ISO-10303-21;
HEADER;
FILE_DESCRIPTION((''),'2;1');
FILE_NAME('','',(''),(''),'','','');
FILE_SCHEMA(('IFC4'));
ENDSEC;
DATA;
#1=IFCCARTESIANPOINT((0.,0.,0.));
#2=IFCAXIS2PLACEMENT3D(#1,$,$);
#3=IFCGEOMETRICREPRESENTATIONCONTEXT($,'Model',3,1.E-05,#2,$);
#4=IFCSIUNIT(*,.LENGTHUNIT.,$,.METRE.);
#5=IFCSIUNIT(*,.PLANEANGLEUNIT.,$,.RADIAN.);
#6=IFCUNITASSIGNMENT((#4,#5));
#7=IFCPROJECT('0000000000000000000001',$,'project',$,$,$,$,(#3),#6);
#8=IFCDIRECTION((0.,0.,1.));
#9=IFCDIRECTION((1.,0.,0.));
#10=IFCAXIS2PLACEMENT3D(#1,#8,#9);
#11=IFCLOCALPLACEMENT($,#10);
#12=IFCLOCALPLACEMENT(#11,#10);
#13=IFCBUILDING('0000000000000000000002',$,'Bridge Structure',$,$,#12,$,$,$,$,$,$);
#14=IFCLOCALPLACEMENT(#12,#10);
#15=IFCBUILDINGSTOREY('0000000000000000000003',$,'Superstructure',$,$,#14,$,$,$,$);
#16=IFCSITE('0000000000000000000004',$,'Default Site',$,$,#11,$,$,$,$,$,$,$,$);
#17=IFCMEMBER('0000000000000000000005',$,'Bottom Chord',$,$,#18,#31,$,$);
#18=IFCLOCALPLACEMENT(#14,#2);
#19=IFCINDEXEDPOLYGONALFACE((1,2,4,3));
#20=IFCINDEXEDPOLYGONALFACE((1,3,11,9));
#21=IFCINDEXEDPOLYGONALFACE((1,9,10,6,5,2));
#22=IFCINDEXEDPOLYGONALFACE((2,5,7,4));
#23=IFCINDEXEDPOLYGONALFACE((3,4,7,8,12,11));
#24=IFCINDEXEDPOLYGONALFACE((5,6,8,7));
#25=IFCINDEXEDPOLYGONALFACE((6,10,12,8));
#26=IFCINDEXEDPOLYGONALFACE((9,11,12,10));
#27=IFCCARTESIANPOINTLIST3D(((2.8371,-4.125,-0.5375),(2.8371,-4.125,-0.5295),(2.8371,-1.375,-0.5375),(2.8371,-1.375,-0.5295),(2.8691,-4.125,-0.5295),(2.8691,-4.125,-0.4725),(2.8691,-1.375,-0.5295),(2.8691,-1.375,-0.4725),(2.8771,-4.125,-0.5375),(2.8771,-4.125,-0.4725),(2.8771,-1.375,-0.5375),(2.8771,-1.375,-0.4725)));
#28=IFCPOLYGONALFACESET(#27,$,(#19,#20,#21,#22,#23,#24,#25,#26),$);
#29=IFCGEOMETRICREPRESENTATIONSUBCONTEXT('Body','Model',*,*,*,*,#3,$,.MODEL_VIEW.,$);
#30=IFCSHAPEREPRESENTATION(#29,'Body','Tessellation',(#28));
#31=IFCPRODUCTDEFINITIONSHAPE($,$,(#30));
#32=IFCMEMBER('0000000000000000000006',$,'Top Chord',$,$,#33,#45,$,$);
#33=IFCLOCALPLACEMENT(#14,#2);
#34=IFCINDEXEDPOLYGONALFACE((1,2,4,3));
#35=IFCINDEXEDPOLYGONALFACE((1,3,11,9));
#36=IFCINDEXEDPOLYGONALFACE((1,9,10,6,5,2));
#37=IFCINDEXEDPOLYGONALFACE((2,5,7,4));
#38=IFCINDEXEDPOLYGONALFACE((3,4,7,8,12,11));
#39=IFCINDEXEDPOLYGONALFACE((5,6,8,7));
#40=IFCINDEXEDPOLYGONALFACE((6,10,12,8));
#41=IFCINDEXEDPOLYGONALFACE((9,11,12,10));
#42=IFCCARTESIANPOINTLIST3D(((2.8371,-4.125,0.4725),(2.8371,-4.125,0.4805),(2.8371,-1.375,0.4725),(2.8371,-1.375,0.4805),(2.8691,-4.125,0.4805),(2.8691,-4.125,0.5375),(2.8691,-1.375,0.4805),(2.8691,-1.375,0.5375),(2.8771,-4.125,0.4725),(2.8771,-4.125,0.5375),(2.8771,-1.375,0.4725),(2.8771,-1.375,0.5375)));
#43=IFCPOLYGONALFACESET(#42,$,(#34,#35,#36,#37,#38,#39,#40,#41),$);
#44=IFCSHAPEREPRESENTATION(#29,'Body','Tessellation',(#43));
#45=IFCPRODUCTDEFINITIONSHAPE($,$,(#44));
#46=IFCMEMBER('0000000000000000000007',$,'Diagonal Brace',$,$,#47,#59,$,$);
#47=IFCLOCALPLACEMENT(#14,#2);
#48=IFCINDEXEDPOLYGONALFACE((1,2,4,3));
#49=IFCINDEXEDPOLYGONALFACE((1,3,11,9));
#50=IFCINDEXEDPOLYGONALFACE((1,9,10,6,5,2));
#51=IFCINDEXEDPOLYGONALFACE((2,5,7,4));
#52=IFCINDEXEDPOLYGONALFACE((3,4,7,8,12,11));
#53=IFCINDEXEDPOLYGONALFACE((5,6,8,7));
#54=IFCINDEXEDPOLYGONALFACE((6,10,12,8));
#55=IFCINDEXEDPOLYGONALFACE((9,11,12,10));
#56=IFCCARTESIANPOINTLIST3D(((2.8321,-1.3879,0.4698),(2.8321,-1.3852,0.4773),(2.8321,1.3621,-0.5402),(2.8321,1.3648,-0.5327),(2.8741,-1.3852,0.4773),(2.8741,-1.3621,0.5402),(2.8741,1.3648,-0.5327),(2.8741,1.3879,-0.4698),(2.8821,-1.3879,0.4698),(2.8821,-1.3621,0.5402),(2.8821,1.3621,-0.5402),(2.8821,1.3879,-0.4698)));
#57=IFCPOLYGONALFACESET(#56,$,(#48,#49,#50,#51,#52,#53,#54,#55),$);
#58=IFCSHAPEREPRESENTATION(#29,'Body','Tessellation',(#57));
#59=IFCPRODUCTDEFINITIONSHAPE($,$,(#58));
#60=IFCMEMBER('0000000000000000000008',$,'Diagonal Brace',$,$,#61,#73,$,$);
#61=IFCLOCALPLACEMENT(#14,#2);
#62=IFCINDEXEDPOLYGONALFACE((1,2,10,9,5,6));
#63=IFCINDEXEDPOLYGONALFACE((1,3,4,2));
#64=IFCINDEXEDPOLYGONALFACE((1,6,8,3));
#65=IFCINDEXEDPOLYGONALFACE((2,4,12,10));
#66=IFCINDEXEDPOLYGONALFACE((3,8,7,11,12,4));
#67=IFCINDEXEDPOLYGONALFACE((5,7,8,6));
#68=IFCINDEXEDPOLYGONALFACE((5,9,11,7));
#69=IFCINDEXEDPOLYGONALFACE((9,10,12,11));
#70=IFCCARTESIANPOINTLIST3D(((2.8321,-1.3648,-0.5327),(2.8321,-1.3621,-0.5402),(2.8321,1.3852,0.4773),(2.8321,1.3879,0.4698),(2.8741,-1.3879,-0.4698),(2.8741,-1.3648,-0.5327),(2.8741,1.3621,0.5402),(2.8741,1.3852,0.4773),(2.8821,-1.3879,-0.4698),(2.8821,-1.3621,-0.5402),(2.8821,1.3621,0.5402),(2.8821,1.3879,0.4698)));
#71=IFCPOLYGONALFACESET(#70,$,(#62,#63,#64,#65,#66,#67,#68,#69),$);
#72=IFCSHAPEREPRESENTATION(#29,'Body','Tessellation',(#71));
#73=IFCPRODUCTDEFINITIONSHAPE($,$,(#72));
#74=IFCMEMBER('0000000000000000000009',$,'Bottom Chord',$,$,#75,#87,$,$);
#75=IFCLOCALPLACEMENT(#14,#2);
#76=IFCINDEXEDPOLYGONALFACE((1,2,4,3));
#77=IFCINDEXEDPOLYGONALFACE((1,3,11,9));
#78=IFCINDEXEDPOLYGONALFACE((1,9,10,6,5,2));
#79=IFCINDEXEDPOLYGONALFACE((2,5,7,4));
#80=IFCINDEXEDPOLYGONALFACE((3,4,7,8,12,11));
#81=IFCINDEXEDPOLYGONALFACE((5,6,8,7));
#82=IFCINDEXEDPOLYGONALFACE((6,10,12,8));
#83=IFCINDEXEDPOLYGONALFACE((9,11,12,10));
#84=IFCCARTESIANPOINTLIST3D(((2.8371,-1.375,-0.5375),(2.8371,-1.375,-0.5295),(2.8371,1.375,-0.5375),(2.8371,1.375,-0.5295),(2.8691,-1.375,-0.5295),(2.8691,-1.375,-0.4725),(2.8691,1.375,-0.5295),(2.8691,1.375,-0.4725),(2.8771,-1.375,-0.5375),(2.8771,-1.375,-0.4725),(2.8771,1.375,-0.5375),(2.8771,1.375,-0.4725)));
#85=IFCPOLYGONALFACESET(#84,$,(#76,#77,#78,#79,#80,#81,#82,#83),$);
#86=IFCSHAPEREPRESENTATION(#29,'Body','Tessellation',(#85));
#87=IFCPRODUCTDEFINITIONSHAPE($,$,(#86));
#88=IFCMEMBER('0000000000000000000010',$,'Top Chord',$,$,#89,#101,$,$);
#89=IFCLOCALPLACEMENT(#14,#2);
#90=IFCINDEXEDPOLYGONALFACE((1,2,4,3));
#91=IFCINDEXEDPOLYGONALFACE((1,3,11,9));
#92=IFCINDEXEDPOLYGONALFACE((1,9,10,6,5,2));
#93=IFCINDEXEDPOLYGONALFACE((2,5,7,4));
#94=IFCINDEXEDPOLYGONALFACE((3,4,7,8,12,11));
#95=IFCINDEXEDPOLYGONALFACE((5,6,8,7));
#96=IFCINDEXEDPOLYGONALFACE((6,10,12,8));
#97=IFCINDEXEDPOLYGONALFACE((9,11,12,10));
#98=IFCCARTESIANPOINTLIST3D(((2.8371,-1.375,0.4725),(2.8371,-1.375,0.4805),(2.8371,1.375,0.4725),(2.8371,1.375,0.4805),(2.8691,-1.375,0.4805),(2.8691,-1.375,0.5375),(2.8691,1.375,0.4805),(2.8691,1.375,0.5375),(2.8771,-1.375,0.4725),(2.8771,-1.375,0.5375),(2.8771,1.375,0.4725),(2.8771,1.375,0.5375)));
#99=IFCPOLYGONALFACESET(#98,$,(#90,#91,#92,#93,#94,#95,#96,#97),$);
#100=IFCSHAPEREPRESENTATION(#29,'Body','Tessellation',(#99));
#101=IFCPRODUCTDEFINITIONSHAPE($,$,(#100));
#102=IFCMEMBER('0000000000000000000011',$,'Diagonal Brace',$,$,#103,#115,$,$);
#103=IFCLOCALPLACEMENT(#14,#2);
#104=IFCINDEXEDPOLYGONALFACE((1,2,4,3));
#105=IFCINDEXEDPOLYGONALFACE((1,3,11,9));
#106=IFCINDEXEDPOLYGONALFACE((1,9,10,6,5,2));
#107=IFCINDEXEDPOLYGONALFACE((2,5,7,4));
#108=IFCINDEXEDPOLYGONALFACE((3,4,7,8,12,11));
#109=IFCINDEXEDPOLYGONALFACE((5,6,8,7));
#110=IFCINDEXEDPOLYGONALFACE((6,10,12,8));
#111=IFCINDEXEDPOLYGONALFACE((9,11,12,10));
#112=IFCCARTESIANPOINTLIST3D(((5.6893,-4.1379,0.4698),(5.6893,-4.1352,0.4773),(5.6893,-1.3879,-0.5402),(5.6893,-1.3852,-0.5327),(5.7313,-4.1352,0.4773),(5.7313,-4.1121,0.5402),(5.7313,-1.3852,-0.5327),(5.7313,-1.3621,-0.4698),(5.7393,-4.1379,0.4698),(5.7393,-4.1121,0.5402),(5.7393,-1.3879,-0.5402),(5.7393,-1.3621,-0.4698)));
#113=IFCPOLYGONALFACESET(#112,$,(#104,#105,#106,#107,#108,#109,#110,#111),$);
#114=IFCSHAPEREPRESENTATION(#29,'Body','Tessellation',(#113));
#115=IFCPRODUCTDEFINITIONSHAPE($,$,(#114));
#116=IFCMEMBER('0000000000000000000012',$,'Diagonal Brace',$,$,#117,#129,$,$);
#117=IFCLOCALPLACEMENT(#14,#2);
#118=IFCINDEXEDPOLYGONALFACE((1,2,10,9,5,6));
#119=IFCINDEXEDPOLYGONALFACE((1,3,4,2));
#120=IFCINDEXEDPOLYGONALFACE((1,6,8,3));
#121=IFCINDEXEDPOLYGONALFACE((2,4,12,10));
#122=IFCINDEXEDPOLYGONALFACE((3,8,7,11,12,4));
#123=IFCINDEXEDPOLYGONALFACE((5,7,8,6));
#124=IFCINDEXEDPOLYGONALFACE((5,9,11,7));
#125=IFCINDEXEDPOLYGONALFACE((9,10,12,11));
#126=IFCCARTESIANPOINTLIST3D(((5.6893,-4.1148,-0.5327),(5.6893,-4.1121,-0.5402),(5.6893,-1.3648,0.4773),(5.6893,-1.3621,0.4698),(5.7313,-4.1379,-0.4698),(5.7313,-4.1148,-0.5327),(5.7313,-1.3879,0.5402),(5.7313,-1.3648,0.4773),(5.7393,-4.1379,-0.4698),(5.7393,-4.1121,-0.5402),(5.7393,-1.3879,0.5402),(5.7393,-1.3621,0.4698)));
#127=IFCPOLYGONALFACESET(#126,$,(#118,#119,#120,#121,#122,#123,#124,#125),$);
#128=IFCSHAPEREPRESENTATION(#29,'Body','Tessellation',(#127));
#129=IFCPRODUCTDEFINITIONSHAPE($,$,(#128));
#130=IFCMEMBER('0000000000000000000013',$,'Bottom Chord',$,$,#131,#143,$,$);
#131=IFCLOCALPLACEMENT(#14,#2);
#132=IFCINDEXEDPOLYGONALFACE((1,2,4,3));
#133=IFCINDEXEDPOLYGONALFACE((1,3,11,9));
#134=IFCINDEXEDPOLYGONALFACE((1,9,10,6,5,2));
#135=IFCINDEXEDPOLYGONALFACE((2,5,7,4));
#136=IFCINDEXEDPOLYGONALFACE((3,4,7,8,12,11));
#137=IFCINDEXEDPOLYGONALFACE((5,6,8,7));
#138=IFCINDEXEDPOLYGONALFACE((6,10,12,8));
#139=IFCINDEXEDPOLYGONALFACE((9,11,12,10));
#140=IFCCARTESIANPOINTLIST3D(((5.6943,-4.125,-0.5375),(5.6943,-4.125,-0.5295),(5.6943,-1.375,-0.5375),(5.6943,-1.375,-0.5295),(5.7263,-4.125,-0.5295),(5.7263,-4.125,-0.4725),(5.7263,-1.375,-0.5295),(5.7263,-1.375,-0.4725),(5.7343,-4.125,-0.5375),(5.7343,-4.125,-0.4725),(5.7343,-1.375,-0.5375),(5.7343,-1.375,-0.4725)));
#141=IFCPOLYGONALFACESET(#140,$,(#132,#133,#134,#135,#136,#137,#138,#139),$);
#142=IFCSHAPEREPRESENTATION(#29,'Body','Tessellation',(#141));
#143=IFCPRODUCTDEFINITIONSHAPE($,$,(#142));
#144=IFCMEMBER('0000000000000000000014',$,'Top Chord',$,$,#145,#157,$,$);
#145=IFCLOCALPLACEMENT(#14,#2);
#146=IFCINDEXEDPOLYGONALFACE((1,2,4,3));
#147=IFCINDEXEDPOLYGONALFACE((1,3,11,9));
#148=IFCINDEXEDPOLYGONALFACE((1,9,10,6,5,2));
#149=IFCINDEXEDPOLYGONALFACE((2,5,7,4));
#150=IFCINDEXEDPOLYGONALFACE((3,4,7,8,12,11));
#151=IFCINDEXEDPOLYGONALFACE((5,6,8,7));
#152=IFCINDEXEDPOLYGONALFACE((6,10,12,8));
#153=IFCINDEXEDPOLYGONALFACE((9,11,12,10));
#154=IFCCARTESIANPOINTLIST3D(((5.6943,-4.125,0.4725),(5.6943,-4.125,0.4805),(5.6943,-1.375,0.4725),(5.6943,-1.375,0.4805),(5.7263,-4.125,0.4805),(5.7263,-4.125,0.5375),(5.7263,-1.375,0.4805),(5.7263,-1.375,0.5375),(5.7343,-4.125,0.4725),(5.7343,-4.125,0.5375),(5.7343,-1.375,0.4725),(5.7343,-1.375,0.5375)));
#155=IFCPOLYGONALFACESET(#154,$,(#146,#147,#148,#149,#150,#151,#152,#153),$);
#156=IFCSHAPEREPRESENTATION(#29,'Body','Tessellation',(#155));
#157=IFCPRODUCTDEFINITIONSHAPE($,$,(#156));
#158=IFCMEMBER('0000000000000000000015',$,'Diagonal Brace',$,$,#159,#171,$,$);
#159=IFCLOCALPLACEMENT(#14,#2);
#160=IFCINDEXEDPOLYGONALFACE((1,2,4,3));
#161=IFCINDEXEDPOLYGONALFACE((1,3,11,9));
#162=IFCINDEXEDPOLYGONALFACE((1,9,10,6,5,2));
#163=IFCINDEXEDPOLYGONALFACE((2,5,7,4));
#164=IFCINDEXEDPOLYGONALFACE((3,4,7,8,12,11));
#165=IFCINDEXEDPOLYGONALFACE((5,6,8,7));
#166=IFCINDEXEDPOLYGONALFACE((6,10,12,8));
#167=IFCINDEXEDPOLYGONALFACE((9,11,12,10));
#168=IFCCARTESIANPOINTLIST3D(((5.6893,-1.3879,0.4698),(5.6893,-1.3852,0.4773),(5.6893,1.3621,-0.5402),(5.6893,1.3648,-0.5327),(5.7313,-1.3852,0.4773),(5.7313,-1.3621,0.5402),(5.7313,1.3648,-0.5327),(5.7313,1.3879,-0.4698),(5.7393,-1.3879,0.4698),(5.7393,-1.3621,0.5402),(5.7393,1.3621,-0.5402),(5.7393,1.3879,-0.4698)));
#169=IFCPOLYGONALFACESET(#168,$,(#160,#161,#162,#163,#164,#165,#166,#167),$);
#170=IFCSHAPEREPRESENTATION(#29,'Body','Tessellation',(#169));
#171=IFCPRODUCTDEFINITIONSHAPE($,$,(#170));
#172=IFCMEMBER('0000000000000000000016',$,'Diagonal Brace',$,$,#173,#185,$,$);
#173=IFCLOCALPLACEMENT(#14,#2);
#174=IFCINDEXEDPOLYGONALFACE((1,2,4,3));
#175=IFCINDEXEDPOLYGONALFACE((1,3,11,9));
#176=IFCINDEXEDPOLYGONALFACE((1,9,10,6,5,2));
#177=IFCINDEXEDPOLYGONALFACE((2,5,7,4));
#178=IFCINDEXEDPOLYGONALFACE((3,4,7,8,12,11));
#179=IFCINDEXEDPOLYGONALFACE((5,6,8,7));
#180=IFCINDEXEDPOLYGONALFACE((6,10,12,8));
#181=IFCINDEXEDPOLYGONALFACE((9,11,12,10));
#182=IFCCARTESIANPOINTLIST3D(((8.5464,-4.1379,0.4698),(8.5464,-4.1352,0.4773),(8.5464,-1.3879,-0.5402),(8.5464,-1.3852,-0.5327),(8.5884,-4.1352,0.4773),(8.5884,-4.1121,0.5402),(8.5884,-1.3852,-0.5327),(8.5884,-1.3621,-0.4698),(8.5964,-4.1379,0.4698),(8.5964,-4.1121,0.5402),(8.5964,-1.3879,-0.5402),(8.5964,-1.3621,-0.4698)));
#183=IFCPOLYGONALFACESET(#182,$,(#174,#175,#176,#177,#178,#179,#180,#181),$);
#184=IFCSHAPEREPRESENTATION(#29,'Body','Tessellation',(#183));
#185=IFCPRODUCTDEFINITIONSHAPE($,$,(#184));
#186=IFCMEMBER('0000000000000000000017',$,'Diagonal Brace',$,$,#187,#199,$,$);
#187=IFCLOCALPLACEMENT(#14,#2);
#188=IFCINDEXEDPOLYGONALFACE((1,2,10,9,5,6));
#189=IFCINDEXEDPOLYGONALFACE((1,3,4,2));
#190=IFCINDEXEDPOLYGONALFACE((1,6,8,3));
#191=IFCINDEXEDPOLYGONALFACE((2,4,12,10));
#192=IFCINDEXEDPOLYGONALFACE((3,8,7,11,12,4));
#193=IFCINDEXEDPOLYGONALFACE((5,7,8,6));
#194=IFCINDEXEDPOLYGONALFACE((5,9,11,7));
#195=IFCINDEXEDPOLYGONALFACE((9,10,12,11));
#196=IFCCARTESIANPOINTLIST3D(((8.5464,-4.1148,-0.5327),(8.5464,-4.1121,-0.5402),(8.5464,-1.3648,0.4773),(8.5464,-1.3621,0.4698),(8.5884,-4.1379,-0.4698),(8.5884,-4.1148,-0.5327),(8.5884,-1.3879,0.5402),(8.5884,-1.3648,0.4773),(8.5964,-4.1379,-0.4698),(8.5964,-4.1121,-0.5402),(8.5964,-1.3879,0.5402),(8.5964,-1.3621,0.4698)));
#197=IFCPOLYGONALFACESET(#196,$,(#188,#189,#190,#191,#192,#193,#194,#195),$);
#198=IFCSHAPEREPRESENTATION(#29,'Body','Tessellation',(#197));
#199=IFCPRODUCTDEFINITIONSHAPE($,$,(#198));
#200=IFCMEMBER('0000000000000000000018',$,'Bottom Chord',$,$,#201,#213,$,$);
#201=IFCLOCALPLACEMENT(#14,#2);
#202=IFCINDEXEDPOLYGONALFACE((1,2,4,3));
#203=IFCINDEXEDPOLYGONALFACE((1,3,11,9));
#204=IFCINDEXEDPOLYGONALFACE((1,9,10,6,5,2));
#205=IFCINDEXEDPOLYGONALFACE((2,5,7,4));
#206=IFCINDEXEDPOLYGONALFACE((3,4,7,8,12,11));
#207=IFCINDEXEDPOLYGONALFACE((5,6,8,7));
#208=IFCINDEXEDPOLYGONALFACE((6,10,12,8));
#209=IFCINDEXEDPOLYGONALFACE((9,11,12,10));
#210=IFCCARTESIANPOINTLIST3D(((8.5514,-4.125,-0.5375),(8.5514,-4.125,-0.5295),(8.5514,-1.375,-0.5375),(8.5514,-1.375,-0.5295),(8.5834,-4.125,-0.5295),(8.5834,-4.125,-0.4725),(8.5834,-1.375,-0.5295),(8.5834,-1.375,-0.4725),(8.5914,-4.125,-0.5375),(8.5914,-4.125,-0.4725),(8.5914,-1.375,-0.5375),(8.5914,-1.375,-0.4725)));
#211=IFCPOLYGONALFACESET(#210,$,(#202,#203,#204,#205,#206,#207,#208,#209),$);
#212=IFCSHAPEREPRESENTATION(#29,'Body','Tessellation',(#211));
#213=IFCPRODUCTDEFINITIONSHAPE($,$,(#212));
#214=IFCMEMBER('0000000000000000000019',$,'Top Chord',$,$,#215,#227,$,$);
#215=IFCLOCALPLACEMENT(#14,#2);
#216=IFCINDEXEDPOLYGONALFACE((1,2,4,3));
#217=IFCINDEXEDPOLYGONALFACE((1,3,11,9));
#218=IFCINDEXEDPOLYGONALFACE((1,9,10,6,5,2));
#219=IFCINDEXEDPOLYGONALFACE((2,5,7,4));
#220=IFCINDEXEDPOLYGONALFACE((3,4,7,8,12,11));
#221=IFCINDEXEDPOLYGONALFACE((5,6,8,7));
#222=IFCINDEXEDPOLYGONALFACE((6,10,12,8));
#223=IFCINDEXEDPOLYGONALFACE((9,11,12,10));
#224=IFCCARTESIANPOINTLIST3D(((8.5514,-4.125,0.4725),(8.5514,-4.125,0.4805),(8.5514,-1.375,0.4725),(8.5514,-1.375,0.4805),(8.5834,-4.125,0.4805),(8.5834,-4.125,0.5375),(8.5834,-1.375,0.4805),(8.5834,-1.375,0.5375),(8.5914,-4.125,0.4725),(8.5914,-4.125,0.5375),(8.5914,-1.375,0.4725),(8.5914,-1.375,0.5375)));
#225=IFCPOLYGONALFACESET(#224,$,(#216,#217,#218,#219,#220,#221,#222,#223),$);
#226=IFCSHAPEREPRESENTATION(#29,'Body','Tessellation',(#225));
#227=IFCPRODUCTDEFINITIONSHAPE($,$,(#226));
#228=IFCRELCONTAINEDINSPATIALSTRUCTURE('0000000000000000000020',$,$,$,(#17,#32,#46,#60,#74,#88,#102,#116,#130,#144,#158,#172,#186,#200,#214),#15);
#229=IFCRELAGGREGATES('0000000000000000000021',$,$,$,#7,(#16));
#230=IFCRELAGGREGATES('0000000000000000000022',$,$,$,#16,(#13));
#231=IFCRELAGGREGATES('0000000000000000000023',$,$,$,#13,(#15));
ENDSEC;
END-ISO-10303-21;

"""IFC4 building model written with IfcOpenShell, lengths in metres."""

from ifc_helpers import new_model, si_unit, frame, origin, origin_with_axes, origin_2d_with_axis, place, context, subcontext, project, spatial, l_section, extrude, element, save


model = new_model("IFC4")

# Units and contexts
model_context = context("Model", 3, precision=1e-05, world=origin())
body_context = subcontext(model_context, "Body", "Model", "MODEL_VIEW")
ifc_project = project(units=[si_unit("LENGTHUNIT", "METRE"), si_unit("PLANEANGLEUNIT", "RADIAN")], contexts=[model_context])

# Site, building, storey
site_placement = place(None, origin_with_axes())
site = spatial("IfcSite", under=ifc_project, at=site_placement, Name="Default Site")
building_placement = place(site_placement, origin_with_axes())
building = spatial("IfcBuilding", under=site, at=building_placement, Name="Bridge Structure")
storey_placement = place(building_placement, origin_with_axes())
storey = spatial("IfcBuildingStorey", under=building, at=storey_placement, Name="Superstructure")

# Members
for number, where, z_axis, x_axis, name in (
    (1, (2.8571, -4.125, -0.505), (0.0, 1.0, 0.0), (-1.0, 0.0, 0.0), "Bottom Chord"),
    (2, (2.8571, -4.125, 0.505), (0.0, 1.0, 0.0), (-1.0, 0.0, 0.0), "Top Chord"),
):
    element("IfcMember", number, at=place(storey_placement, frame(where, z_axis=z_axis, x_axis=x_axis)), inside=storey, Name=name, context=body_context, shape_type="SweptSolid", body=[
        extrude(l_section(Depth=0.065, Width=0.04, Thickness=0.008, at=origin_2d_with_axis()), origin_with_axes(), (0.0, 0.0, 1.0), 2.75),
    ])
for number, where, z_axis, x_axis, name in (
    (3, (2.8571, -1.375, 0.505), (0.0, 0.938692, -0.344756), (-1.0, 0.0, 0.0), "Diagonal Brace"),
    (4, (2.8571, -1.375, -0.505), (0.0, 0.938692, 0.344756), (-1.0, 0.0, 0.0), "Diagonal Brace"),
):
    element("IfcMember", number, at=place(storey_placement, frame(where, z_axis=z_axis, x_axis=x_axis)), inside=storey, Name=name, context=body_context, shape_type="SweptSolid", body=[
        extrude(l_section(Depth=0.075, Width=0.05, Thickness=0.008, at=origin_2d_with_axis()), origin_with_axes(), (0.0, 0.0, 1.0), 2.9296),
    ])
for number, where, z_axis, x_axis, name in (
    (5, (2.8571, -1.375, -0.505), (0.0, 1.0, 0.0), (-1.0, 0.0, 0.0), "Bottom Chord"),
    (6, (2.8571, -1.375, 0.505), (0.0, 1.0, 0.0), (-1.0, 0.0, 0.0), "Top Chord"),
):
    element("IfcMember", number, at=place(storey_placement, frame(where, z_axis=z_axis, x_axis=x_axis)), inside=storey, Name=name, context=body_context, shape_type="SweptSolid", body=[
        extrude(l_section(Depth=0.065, Width=0.04, Thickness=0.008, at=origin_2d_with_axis()), origin_with_axes(), (0.0, 0.0, 1.0), 2.75),
    ])
for number, where, z_axis, x_axis, name in (
    (7, (5.7143, -4.125, 0.505), (0.0, 0.938692, -0.344756), (-1.0, 0.0, 0.0), "Diagonal Brace"),
    (8, (5.7143, -4.125, -0.505), (0.0, 0.938692, 0.344756), (-1.0, 0.0, 0.0), "Diagonal Brace"),
):
    element("IfcMember", number, at=place(storey_placement, frame(where, z_axis=z_axis, x_axis=x_axis)), inside=storey, Name=name, context=body_context, shape_type="SweptSolid", body=[
        extrude(l_section(Depth=0.075, Width=0.05, Thickness=0.008, at=origin_2d_with_axis()), origin_with_axes(), (0.0, 0.0, 1.0), 2.9296),
    ])
for number, where, z_axis, x_axis, name in (
    (9, (5.7143, -4.125, -0.505), (0.0, 1.0, 0.0), (-1.0, 0.0, 0.0), "Bottom Chord"),
    (10, (5.7143, -4.125, 0.505), (0.0, 1.0, 0.0), (-1.0, 0.0, 0.0), "Top Chord"),
):
    element("IfcMember", number, at=place(storey_placement, frame(where, z_axis=z_axis, x_axis=x_axis)), inside=storey, Name=name, context=body_context, shape_type="SweptSolid", body=[
        extrude(l_section(Depth=0.065, Width=0.04, Thickness=0.008, at=origin_2d_with_axis()), origin_with_axes(), (0.0, 0.0, 1.0), 2.75),
    ])
for number, where, z_axis, x_axis, name in (
    (11, (5.7143, -1.375, 0.505), (0.0, 0.938692, -0.344756), (-1.0, 0.0, 0.0), "Diagonal Brace"),
    (12, (8.5714, -4.125, 0.505), (0.0, 0.938692, -0.344756), (-1.0, 0.0, 0.0), "Diagonal Brace"),
    (13, (8.5714, -4.125, -0.505), (0.0, 0.938692, 0.344756), (-1.0, 0.0, 0.0), "Diagonal Brace"),
):
    element("IfcMember", number, at=place(storey_placement, frame(where, z_axis=z_axis, x_axis=x_axis)), inside=storey, Name=name, context=body_context, shape_type="SweptSolid", body=[
        extrude(l_section(Depth=0.075, Width=0.05, Thickness=0.008, at=origin_2d_with_axis()), origin_with_axes(), (0.0, 0.0, 1.0), 2.9296),
    ])
for number, where, z_axis, x_axis, name in (
    (14, (8.5714, -4.125, -0.505), (0.0, 1.0, 0.0), (-1.0, 0.0, 0.0), "Bottom Chord"),
    (15, (8.5714, -4.125, 0.505), (0.0, 1.0, 0.0), (-1.0, 0.0, 0.0), "Top Chord"),
):
    element("IfcMember", number, at=place(storey_placement, frame(where, z_axis=z_axis, x_axis=x_axis)), inside=storey, Name=name, context=body_context, shape_type="SweptSolid", body=[
        extrude(l_section(Depth=0.065, Width=0.04, Thickness=0.008, at=origin_2d_with_axis()), origin_with_axes(), (0.0, 0.0, 1.0), 2.75),
    ])

save(model, "model.ifc")
